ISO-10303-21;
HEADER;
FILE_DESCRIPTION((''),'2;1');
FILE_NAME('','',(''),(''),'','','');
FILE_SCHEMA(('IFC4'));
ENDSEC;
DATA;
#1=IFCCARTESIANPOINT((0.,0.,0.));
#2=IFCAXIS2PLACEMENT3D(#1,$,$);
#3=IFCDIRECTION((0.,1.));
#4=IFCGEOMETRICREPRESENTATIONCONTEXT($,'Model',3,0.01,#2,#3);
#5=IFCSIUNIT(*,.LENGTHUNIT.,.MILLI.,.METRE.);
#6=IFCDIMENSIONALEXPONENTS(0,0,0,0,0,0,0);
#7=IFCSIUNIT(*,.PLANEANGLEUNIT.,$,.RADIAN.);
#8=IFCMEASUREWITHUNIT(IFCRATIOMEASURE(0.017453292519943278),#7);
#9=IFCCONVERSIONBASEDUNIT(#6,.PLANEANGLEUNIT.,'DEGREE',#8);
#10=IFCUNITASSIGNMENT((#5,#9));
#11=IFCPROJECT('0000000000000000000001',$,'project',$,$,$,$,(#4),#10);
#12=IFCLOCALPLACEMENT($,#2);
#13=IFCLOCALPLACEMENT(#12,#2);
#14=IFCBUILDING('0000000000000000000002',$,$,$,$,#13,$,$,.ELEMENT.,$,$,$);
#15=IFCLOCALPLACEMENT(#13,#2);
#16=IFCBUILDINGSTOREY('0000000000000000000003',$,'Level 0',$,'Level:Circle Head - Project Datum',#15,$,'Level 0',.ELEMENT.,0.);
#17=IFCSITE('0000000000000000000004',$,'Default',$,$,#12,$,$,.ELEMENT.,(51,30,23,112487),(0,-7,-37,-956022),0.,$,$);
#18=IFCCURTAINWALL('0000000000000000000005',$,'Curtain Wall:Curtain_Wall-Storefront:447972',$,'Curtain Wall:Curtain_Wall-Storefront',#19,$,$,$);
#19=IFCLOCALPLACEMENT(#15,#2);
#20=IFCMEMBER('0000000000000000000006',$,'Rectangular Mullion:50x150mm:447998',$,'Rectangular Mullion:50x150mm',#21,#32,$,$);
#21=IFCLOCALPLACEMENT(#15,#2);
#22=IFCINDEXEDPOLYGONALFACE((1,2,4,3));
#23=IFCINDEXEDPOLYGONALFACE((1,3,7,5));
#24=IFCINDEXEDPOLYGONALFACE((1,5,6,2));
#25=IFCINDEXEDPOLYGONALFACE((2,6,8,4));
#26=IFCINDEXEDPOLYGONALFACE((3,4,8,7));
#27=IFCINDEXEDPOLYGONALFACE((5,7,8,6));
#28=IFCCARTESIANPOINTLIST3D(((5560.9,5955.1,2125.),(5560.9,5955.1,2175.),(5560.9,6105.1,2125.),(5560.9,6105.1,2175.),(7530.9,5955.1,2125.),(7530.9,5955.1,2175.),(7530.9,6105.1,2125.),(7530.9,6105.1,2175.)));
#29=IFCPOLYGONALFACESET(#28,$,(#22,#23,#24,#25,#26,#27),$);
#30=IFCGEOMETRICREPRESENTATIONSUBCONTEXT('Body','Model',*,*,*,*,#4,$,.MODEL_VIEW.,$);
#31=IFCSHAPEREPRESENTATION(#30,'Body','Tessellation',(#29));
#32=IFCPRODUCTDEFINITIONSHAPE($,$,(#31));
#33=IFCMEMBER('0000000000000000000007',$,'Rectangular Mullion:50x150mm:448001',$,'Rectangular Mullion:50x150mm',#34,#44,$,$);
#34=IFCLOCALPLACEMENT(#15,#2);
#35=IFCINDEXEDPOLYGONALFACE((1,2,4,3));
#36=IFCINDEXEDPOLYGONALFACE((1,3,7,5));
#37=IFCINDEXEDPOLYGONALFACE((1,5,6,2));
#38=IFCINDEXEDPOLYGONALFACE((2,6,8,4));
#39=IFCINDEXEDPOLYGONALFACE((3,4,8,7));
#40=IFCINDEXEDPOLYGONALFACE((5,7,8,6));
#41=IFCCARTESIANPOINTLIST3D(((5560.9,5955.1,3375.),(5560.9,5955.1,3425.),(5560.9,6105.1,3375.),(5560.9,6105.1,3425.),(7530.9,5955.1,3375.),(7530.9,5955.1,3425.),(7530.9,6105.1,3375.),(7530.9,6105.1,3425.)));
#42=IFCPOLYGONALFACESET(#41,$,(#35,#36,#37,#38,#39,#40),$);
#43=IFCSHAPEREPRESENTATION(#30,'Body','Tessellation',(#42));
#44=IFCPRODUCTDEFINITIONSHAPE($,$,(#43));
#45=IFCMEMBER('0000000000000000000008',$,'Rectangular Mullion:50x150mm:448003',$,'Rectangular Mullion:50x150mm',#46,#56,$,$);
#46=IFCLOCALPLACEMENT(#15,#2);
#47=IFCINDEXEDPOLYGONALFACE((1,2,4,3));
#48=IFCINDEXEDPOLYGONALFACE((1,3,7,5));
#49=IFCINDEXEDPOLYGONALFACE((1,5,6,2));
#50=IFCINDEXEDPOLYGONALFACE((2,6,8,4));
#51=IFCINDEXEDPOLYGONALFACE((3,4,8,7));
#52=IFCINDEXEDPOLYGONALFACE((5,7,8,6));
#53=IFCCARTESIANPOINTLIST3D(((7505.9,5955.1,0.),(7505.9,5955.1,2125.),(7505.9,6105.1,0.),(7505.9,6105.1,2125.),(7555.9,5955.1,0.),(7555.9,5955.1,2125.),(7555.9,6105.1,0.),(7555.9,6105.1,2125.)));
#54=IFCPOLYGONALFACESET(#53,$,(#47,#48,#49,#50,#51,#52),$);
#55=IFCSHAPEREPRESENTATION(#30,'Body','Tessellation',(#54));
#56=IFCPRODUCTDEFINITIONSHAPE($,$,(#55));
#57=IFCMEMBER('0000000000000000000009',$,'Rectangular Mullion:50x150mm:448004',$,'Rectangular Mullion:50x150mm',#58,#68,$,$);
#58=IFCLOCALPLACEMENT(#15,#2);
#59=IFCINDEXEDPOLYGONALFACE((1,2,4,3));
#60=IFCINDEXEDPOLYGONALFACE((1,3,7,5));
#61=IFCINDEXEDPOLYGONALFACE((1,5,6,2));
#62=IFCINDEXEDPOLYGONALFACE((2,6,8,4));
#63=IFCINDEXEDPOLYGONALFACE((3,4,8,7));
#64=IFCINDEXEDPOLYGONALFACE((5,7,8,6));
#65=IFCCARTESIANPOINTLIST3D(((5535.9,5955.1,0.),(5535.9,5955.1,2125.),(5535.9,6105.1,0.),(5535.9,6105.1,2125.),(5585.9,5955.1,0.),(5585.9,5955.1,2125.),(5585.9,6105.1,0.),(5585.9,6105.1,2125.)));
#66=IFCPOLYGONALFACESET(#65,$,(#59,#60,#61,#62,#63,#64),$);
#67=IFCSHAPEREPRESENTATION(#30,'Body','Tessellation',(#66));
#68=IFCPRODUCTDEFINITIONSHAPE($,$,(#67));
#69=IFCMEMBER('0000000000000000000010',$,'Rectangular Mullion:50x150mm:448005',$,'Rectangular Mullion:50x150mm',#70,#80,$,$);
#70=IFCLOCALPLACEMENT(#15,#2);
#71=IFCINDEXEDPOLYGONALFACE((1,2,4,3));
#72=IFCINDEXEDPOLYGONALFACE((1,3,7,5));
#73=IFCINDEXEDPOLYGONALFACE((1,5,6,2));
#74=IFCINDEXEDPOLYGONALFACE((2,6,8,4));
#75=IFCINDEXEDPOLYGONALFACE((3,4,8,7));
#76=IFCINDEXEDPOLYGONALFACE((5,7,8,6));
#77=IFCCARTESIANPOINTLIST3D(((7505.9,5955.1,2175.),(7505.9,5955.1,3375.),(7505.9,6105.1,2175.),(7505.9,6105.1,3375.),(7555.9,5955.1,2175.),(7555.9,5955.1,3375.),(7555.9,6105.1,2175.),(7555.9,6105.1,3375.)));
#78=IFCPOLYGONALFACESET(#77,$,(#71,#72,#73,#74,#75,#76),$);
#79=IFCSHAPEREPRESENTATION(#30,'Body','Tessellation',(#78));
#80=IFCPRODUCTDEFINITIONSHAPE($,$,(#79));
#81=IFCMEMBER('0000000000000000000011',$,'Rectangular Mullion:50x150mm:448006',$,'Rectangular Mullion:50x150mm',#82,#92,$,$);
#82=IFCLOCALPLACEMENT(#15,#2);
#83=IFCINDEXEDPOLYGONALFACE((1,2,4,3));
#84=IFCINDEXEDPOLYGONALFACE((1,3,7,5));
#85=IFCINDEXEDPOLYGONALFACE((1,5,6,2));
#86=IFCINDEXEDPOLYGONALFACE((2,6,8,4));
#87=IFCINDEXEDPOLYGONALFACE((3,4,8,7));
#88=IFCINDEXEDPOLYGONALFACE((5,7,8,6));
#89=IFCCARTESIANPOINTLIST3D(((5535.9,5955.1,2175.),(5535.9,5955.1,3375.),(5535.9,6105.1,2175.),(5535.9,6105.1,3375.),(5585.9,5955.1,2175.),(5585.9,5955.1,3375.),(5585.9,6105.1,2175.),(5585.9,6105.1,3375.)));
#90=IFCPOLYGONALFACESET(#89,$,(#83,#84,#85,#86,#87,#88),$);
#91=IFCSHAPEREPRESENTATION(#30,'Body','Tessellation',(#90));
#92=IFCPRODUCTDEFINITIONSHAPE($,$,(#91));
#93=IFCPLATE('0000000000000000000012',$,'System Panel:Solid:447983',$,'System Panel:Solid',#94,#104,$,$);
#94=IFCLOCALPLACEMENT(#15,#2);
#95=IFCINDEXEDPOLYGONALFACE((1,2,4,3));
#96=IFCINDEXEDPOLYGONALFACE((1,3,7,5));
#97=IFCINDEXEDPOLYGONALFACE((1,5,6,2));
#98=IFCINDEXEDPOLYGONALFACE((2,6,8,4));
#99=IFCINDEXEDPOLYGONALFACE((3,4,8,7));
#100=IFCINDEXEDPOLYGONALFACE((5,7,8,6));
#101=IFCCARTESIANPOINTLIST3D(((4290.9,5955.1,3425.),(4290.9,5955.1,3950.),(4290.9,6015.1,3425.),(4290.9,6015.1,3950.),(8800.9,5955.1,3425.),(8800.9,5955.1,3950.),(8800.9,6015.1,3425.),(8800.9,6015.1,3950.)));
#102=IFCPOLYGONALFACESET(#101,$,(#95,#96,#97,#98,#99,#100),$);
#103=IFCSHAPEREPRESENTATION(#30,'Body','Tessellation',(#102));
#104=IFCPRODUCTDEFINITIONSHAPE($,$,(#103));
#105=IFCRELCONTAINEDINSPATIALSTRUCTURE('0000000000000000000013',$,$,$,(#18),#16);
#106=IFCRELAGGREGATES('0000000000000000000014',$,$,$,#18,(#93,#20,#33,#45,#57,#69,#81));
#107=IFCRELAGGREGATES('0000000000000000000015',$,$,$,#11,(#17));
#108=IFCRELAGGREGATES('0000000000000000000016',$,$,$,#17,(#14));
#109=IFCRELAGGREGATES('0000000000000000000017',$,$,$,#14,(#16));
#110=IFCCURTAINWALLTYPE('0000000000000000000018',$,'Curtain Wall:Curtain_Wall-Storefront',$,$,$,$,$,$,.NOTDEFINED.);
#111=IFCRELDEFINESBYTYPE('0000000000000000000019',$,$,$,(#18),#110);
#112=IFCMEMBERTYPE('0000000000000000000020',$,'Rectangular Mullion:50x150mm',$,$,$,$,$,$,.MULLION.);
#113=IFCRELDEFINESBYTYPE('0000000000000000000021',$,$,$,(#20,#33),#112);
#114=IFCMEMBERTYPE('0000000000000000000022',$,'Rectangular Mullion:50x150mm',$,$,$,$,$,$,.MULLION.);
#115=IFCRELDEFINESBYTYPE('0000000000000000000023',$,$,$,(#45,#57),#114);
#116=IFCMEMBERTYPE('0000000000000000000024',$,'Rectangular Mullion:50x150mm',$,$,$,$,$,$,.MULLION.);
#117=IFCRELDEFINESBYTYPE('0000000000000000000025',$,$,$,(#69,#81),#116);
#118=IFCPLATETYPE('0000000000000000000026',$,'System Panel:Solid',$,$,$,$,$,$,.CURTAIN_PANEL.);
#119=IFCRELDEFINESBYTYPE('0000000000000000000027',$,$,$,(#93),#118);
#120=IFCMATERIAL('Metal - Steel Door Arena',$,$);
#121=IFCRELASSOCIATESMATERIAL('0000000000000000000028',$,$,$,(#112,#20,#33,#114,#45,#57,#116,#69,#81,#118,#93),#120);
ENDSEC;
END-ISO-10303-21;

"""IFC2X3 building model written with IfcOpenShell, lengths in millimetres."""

from ifc_helpers import new_model, entity, si_unit, converted_unit, direction, frame, frame_2d, origin, origin_2d_with_axis, place, context, subcontext, project, spatial, rectangle, extrude, source, transform, mapped, material, type_object, type_shapes, element, aggregate, save


model = new_model("IFC2X3")

# Units and contexts
model_context = context("Model", 3, precision=0.01, world=origin(), true_north=direction((0.0, 1.0)))
body_context = subcontext(model_context, "Body", "Model", "MODEL_VIEW")
ifc_project = project(units=[si_unit("LENGTHUNIT", "METRE", prefix="MILLI"), converted_unit("PLANEANGLEUNIT", "DEGREE", entity("IfcRatioMeasure", 0.017453292519943278), si_unit("PLANEANGLEUNIT", "RADIAN"), dimensions=[0, 0, 0, 0, 0, 0, 0])], contexts=[model_context])

# Site, building, storey
site_placement = place(None, origin())
site = spatial("IfcSite", under=ifc_project, at=site_placement, Name="Default", CompositionType="ELEMENT", RefLatitude=(51, 30, 23, 112487), RefLongitude=(0, -7, -37, -956022), RefElevation=0.0)
building_placement = place(site_placement, origin())
building = spatial("IfcBuilding", under=site, at=building_placement, CompositionType="ELEMENT")
storey_placement = place(building_placement, origin())
storey = spatial("IfcBuildingStorey", under=building, at=storey_placement, Name="Level 0", ObjectType="Level:Circle Head - Project Datum", LongName="Level 0", CompositionType="ELEMENT", Elevation=0.0)

# Curtain wall
curtain_wall_type = type_object("IfcCurtainWallType", Name="Curtain Wall:Curtain_Wall-Storefront", PredefinedType="NOTDEFINED")
curtain_wall_1_placement = place(storey_placement, origin())
curtain_wall_1 = element("IfcCurtainWall", 1, at=curtain_wall_1_placement, inside=storey, type_object=curtain_wall_type, Name="Curtain Wall:Curtain_Wall-Storefront:447972", ObjectType="Curtain Wall:Curtain_Wall-Storefront")
ifc_material_1 = material(Name="Metal - Steel Door Arena")

# Members
member_type_1 = type_object("IfcMemberType", Name="Rectangular Mullion:50x150mm", PredefinedType="MULLION", material=ifc_material_1)
shared_shape_1 = source(origin(), body_context, "Body", "SweptSolid", [
    extrude(rectangle(XDim=150.0, YDim=50.0, at=origin_2d_with_axis()), frame((0.0, 0.0, -1970.0), z_axis=(0.0, 0.0, 1.0), x_axis=(0.0, -1.0, 0.0)), (0.0, 0.0, 1.0), 1970.0),
])
type_shapes(member_type_1, [shared_shape_1])
member_1_placement = place(curtain_wall_1_placement, frame((5560.9, 6030.1, 2150.0), z_axis=(-1.0, 0.0, 0.0), x_axis=(0.0, 0.0, 1.0)))
member_1 = element("IfcMember", 2, at=member_1_placement, type_object=member_type_1, material=ifc_material_1, Name="Rectangular Mullion:50x150mm:447998", ObjectType="Rectangular Mullion:50x150mm", context=body_context, shape_type="MappedRepresentation", body=[
    mapped(shared_shape_1, transform((0.0, 0.0, 0.0), scale=1.0)),
])
member_2_placement = place(curtain_wall_1_placement, frame((5560.9, 6030.1, 3400.0), z_axis=(-1.0, 0.0, 0.0), x_axis=(0.0, 0.0, 1.0)))
member_2 = element("IfcMember", 3, at=member_2_placement, type_object=member_type_1, material=ifc_material_1, Name="Rectangular Mullion:50x150mm:448001", ObjectType="Rectangular Mullion:50x150mm", context=body_context, shape_type="MappedRepresentation", body=[
    mapped(shared_shape_1, transform((0.0, 0.0, 0.0), scale=1.0)),
])
member_type_2 = type_object("IfcMemberType", Name="Rectangular Mullion:50x150mm", PredefinedType="MULLION", material=ifc_material_1)
shared_shape_2 = source(origin(), body_context, "Body", "SweptSolid", [
    extrude(rectangle(XDim=150.0, YDim=50.0, at=origin_2d_with_axis()), frame((0.0, 0.0, -2125.0), z_axis=(0.0, 0.0, 1.0), x_axis=(0.0, -1.0, 0.0)), (0.0, 0.0, 1.0), 2125.0),
])
type_shapes(member_type_2, [shared_shape_2])
member_3_placement = place(curtain_wall_1_placement, frame((7530.9, 6030.1, 0.0), z_axis=(0.0, 0.0, -1.0), x_axis=(-1.0, 0.0, 0.0)))
member_3 = element("IfcMember", 4, at=member_3_placement, type_object=member_type_2, material=ifc_material_1, Name="Rectangular Mullion:50x150mm:448003", ObjectType="Rectangular Mullion:50x150mm", context=body_context, shape_type="MappedRepresentation", body=[
    mapped(shared_shape_2, transform((0.0, 0.0, 0.0), scale=1.0)),
])
member_4_placement = place(curtain_wall_1_placement, frame((5560.9, 6030.1, 0.0), z_axis=(0.0, 0.0, -1.0), x_axis=(-1.0, 0.0, 0.0)))
member_4 = element("IfcMember", 5, at=member_4_placement, type_object=member_type_2, material=ifc_material_1, Name="Rectangular Mullion:50x150mm:448004", ObjectType="Rectangular Mullion:50x150mm", context=body_context, shape_type="MappedRepresentation", body=[
    mapped(shared_shape_2, transform((0.0, 0.0, 0.0), scale=1.0)),
])
member_type_3 = type_object("IfcMemberType", Name="Rectangular Mullion:50x150mm", PredefinedType="MULLION", material=ifc_material_1)
shared_shape_3 = source(origin(), body_context, "Body", "SweptSolid", [
    extrude(rectangle(XDim=150.0, YDim=50.0, at=origin_2d_with_axis()), frame((0.0, 0.0, -1200.0), z_axis=(0.0, 0.0, 1.0), x_axis=(0.0, -1.0, 0.0)), (0.0, 0.0, 1.0), 1200.0),
])
type_shapes(member_type_3, [shared_shape_3])
member_5_placement = place(curtain_wall_1_placement, frame((7530.9, 6030.1, 2175.0), z_axis=(0.0, 0.0, -1.0), x_axis=(-1.0, 0.0, 0.0)))
member_5 = element("IfcMember", 6, at=member_5_placement, type_object=member_type_3, material=ifc_material_1, Name="Rectangular Mullion:50x150mm:448005", ObjectType="Rectangular Mullion:50x150mm", context=body_context, shape_type="MappedRepresentation", body=[
    mapped(shared_shape_3, transform((0.0, 0.0, 0.0), scale=1.0)),
])
member_6_placement = place(curtain_wall_1_placement, frame((5560.9, 6030.1, 2175.0), z_axis=(0.0, 0.0, -1.0), x_axis=(-1.0, 0.0, 0.0)))
member_6 = element("IfcMember", 7, at=member_6_placement, type_object=member_type_3, material=ifc_material_1, Name="Rectangular Mullion:50x150mm:448006", ObjectType="Rectangular Mullion:50x150mm", context=body_context, shape_type="MappedRepresentation", body=[
    mapped(shared_shape_3, transform((0.0, 0.0, 0.0), scale=1.0)),
])

# Plate
plate_type_1 = type_object("IfcPlateType", Name="System Panel:Solid", PredefinedType="CURTAIN_PANEL", material=ifc_material_1)
shared_shape_4 = source(origin(), body_context, "Body", "SweptSolid", [
    extrude(rectangle(XDim=525.0, YDim=4510.0, at=frame_2d((0.0, 0.0), x_axis=(1.0, 0.0))), frame((0.0, 15.0, 262.5), z_axis=(0.0, 1.0, 0.0), x_axis=(0.0, 0.0, 1.0)), (0.0, 0.0, 1.0), 60.0),
])
type_shapes(plate_type_1, [shared_shape_4])
plate_1_placement = place(curtain_wall_1_placement, frame((6545.9, 6030.1, 3425.0), z_axis=(0.0, 0.0, 1.0), x_axis=(-1.0, 0.0, 0.0)))
plate_1 = element("IfcPlate", 8, at=plate_1_placement, type_object=plate_type_1, material=ifc_material_1, Name="System Panel:Solid:447983", ObjectType="System Panel:Solid", context=body_context, shape_type="MappedRepresentation", body=[
    mapped(shared_shape_4, transform((0.0, 0.0, 0.0), scale=1.0)),
])
aggregate(curtain_wall_1, [plate_1, member_1, member_2, member_3, member_4, member_5, member_6])

save(model, "model.ifc")
